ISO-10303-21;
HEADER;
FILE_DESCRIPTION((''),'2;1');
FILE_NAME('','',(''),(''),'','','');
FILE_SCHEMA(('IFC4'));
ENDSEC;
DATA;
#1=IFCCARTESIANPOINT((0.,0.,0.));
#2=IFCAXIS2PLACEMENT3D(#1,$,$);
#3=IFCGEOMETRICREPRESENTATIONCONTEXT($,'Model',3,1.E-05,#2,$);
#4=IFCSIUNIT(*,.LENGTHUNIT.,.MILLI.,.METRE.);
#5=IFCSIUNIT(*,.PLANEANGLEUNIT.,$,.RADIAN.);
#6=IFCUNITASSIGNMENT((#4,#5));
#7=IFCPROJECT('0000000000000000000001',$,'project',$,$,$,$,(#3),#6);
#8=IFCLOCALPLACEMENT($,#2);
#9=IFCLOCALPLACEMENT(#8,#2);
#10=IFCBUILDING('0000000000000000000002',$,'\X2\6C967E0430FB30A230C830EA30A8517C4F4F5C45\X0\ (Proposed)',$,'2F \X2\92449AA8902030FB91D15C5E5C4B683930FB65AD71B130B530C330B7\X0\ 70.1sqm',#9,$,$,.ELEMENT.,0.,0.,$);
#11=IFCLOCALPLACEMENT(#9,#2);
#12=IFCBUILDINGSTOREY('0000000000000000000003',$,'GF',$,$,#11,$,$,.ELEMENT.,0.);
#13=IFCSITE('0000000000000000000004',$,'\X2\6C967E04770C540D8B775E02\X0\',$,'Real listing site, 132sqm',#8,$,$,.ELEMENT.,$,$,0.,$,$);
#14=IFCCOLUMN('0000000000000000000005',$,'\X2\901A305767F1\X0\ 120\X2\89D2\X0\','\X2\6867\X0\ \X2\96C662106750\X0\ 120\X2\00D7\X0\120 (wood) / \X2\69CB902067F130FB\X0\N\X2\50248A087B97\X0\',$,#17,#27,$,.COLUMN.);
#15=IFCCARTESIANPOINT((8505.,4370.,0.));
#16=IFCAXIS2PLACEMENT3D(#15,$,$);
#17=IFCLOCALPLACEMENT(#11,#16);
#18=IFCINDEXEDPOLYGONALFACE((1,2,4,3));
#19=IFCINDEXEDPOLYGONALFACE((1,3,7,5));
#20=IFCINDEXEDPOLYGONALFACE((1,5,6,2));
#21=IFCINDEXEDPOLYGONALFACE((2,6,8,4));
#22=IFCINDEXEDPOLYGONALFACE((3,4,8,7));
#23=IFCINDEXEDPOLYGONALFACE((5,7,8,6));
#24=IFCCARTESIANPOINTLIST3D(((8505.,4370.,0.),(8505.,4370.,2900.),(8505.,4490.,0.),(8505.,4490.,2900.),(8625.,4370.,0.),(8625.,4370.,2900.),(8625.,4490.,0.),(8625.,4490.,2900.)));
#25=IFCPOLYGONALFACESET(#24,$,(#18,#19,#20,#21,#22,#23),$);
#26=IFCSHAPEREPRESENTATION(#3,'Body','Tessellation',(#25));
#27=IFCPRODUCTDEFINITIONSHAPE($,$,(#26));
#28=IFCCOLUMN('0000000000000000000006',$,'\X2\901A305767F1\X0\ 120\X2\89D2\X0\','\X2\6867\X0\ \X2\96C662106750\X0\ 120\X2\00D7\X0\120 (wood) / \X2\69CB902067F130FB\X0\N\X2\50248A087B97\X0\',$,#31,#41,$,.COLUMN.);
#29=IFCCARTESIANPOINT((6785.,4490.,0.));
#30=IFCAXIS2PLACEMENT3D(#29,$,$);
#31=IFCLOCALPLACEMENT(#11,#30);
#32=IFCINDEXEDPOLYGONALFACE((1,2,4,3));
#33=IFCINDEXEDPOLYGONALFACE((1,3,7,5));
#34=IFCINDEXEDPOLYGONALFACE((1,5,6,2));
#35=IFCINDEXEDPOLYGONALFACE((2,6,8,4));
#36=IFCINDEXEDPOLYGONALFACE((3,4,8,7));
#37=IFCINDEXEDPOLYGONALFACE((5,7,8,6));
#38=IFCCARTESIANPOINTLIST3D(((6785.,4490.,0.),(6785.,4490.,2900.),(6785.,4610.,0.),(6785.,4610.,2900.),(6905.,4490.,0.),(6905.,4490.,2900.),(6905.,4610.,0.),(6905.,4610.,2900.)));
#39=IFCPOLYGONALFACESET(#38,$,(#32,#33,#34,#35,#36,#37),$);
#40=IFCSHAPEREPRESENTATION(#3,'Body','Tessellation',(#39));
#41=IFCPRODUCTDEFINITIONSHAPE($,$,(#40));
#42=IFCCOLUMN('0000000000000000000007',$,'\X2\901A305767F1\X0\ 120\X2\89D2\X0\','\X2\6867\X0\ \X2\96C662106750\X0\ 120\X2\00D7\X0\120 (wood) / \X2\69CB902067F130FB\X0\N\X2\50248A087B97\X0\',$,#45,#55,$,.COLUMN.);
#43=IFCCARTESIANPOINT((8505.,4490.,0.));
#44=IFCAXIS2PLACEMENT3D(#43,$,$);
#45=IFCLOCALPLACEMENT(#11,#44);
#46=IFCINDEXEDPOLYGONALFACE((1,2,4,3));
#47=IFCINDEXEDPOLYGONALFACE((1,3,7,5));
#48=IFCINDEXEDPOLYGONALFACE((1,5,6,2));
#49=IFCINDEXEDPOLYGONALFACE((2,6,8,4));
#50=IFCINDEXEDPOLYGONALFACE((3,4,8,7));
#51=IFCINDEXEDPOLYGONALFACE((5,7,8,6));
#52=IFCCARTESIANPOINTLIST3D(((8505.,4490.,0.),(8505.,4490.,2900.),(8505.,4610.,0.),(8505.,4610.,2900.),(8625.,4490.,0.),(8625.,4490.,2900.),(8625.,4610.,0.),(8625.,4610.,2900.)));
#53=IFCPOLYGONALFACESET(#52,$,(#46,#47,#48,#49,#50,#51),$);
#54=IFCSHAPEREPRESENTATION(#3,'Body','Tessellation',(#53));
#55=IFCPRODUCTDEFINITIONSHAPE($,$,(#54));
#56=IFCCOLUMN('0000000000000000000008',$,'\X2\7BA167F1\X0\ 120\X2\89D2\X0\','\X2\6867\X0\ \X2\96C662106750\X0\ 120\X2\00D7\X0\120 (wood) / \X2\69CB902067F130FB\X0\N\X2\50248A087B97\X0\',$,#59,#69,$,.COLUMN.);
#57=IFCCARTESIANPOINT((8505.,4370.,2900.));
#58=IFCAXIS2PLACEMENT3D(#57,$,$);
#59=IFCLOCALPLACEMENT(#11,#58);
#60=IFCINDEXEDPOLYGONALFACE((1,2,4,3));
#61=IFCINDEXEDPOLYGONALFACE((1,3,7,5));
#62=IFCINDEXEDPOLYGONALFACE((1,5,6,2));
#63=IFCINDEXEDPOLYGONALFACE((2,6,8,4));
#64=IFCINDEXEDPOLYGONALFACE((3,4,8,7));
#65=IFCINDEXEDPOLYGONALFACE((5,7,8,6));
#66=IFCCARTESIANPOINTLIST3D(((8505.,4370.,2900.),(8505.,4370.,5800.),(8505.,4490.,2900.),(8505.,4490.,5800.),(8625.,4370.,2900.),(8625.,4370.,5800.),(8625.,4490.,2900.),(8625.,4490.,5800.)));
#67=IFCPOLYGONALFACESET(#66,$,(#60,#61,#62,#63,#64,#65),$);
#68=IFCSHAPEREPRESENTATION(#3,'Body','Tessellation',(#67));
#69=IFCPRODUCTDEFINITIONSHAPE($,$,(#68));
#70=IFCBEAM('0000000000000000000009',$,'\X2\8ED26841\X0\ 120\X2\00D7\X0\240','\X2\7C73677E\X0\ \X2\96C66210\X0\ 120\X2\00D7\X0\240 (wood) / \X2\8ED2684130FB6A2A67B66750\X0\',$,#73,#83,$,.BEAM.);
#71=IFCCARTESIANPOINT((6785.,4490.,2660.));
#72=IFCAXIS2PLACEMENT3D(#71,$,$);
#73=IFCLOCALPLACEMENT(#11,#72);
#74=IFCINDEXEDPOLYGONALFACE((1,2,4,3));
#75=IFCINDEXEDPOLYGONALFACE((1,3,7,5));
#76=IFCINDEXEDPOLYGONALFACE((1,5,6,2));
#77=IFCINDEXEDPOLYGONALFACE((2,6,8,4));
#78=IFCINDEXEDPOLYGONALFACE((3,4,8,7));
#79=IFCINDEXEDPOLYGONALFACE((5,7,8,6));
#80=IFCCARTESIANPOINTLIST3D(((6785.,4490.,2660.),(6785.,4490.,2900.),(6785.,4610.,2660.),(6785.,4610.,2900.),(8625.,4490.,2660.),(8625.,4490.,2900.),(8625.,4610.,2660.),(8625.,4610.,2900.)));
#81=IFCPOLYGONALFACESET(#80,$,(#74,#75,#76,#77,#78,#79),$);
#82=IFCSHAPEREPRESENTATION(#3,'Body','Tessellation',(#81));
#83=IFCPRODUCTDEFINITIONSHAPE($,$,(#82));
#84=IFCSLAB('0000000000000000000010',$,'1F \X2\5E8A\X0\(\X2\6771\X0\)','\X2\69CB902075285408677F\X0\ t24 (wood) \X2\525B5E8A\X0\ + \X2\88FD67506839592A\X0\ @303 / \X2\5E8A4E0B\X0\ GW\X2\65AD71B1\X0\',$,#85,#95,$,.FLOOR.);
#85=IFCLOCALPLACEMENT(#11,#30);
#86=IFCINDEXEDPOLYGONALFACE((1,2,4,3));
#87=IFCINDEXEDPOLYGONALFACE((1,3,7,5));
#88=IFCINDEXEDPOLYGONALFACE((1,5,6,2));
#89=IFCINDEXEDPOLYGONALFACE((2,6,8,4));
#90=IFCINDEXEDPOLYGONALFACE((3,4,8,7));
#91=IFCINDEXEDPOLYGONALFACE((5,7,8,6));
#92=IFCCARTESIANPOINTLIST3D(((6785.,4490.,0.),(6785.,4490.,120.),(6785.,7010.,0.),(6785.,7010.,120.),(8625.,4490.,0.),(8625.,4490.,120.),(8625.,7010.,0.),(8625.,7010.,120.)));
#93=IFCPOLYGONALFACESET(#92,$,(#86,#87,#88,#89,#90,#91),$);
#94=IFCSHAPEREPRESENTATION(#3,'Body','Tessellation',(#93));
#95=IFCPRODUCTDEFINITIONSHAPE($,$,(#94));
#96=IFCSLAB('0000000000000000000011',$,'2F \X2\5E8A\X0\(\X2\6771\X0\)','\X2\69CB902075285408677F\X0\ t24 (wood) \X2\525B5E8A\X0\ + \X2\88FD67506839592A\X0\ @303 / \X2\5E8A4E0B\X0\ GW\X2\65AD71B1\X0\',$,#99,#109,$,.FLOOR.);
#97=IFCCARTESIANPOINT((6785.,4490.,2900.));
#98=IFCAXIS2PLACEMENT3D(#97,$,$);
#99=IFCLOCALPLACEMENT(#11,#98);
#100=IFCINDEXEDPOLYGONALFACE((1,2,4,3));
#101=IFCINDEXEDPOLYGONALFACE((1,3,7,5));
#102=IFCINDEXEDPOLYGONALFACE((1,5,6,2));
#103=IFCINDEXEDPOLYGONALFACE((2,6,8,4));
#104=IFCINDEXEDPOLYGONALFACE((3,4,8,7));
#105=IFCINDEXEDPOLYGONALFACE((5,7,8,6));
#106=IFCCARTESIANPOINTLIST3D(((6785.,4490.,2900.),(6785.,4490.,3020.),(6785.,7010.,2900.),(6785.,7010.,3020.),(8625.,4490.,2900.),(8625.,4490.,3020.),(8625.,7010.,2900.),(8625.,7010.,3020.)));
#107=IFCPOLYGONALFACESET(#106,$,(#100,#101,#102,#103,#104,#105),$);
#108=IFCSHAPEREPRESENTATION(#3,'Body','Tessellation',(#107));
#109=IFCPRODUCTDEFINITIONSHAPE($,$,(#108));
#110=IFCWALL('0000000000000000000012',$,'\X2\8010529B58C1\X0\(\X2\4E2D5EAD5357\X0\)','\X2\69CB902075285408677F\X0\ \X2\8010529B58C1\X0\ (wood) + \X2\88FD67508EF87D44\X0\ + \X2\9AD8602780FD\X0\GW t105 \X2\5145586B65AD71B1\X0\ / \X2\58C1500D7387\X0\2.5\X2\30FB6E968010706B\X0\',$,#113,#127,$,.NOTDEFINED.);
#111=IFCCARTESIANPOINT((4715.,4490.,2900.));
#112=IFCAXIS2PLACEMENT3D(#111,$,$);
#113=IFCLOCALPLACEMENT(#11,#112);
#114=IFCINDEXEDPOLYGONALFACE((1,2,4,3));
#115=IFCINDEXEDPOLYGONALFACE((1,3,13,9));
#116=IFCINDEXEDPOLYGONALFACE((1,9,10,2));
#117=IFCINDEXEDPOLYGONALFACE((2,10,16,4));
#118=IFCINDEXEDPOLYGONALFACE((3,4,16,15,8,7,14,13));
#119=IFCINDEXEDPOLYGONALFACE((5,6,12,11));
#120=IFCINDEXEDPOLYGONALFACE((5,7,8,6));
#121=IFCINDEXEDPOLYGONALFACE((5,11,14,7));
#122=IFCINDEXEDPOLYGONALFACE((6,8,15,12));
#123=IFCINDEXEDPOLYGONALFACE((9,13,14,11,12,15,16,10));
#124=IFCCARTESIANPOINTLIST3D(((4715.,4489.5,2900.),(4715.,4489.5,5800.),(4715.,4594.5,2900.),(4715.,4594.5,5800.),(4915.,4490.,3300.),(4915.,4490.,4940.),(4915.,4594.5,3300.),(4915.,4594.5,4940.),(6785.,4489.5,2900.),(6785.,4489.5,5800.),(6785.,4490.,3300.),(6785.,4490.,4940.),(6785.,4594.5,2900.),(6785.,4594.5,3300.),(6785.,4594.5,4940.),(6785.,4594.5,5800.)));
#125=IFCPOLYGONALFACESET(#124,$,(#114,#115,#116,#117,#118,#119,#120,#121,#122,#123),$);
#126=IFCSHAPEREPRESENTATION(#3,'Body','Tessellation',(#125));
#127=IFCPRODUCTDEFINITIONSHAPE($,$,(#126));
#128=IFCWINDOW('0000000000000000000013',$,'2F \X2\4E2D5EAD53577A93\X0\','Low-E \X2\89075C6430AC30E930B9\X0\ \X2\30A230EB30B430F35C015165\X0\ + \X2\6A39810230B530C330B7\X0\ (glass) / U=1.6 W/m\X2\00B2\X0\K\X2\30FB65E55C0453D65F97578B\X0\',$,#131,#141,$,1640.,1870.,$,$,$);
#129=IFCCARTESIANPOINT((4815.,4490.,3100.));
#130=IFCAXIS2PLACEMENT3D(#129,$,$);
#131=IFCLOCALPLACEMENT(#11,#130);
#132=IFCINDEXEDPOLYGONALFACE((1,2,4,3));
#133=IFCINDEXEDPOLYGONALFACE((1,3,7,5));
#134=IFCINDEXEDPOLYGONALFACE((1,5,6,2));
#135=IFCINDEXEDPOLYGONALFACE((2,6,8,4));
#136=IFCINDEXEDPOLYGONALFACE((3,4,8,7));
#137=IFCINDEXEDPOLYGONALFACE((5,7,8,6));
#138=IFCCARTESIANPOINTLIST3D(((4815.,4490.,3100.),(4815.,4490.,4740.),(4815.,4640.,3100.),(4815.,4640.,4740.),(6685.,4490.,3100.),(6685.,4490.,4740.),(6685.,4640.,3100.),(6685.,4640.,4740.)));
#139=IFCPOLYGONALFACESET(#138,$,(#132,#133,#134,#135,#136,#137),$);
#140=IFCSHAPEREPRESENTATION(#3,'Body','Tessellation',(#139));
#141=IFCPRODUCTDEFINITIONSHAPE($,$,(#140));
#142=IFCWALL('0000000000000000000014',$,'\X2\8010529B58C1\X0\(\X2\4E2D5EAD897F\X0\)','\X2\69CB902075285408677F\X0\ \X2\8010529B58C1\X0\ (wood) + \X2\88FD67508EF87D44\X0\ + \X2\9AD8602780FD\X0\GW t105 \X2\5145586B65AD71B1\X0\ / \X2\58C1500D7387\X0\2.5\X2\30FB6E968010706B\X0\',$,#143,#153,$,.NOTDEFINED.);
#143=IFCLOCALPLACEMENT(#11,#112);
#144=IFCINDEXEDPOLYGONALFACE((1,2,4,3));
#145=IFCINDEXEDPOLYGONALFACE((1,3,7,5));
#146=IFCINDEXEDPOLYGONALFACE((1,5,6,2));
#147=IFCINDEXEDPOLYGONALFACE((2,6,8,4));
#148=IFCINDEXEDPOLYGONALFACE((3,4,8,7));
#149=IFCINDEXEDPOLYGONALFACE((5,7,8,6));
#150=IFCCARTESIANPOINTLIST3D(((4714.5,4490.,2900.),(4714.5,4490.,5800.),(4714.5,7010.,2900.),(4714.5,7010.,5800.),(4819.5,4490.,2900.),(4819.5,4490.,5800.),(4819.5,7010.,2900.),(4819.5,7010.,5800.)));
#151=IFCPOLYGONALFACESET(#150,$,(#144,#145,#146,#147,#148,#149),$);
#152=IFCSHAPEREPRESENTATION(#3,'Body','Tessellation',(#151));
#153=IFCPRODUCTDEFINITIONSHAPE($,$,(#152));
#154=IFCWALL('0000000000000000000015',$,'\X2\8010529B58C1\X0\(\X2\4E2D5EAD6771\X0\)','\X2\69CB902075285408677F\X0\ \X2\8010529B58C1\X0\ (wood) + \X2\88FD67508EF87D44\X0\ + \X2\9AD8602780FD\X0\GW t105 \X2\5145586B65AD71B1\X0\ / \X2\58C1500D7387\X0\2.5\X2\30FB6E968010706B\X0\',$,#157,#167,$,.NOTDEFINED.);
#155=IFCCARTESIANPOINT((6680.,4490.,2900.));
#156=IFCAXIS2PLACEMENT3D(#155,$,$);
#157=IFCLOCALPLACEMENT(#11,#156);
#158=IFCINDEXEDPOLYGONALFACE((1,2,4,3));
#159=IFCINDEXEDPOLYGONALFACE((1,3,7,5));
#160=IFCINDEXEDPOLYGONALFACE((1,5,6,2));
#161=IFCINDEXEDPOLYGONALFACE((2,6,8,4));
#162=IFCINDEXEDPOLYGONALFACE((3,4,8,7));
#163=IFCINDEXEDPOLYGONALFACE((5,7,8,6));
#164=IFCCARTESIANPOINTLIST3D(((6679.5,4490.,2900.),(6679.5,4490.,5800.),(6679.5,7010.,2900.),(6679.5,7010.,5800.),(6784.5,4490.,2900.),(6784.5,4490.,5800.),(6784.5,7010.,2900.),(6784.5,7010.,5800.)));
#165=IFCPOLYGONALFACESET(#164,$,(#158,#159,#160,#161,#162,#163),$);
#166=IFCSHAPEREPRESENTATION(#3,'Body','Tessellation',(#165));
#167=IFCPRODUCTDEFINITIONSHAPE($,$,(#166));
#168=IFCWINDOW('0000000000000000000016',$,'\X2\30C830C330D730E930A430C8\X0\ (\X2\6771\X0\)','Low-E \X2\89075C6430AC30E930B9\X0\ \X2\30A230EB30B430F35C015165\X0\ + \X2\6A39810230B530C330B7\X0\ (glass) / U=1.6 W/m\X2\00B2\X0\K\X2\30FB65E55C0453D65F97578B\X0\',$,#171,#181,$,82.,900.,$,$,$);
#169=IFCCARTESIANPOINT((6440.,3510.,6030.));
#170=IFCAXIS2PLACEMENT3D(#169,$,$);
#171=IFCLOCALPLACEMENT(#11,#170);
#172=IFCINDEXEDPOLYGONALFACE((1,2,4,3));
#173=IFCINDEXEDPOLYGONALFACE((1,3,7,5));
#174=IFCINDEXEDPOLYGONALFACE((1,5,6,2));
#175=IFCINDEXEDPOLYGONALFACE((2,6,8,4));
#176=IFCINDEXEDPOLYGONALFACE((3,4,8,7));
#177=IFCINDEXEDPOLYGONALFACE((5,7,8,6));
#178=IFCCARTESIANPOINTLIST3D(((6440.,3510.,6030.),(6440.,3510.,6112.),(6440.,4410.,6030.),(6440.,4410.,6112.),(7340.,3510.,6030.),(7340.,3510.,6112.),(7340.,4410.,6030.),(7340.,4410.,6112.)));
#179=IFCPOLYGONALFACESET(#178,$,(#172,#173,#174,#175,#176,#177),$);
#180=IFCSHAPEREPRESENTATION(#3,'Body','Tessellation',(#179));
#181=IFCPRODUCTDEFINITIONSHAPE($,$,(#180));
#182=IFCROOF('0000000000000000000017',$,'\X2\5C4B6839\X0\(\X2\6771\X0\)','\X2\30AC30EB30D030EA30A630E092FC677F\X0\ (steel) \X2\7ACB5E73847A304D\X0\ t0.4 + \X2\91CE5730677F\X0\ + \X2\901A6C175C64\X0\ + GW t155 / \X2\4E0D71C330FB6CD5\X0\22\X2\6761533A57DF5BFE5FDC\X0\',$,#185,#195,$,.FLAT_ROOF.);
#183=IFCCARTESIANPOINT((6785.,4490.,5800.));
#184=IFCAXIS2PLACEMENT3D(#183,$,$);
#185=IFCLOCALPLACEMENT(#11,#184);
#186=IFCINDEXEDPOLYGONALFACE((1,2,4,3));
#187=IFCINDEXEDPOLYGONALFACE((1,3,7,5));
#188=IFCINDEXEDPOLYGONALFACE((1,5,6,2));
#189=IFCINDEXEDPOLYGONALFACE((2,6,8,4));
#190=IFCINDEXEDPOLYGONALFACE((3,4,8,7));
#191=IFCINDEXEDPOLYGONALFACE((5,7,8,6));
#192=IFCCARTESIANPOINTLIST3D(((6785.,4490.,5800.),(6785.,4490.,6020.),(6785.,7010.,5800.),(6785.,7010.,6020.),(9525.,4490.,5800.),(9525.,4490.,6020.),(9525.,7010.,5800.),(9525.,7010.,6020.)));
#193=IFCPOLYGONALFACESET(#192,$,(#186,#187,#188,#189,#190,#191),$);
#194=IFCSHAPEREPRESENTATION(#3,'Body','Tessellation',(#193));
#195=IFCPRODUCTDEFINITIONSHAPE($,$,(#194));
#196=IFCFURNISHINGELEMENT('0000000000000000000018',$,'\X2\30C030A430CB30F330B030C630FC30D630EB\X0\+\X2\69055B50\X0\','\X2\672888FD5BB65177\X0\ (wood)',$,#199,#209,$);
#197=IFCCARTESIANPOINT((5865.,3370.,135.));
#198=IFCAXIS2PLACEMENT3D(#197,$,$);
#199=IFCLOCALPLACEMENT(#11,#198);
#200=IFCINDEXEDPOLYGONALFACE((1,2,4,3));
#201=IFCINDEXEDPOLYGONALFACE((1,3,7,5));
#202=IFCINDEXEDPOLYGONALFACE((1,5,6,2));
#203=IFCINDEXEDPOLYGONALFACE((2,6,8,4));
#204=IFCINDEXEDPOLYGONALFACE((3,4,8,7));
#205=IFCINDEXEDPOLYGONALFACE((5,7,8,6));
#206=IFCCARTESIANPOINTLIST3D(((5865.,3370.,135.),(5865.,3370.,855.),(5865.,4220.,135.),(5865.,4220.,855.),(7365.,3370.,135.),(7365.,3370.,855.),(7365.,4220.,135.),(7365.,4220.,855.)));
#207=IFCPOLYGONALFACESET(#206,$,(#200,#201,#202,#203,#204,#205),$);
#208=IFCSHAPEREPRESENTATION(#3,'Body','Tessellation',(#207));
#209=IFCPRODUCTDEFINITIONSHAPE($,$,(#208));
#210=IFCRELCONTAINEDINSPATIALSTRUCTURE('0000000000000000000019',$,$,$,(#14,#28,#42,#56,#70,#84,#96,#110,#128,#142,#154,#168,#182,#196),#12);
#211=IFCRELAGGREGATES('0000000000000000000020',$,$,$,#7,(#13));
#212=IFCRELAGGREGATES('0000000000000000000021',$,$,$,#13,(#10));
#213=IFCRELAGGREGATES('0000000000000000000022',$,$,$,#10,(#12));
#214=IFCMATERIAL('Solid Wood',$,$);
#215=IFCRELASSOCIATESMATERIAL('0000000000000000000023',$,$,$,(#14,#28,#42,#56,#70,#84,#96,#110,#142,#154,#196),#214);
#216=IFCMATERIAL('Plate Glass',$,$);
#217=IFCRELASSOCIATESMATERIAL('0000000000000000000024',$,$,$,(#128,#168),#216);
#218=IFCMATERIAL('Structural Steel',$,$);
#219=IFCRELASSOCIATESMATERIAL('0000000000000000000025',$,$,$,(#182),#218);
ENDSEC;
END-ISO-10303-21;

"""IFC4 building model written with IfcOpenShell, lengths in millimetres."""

from ifc_helpers import new_model, si_unit, frame, frame_2d, origin, place, context, project, spatial, rectangle, extrude, material, element, fill, save


model = new_model("IFC4")

# Units and contexts
model_context = context("Model", 3, precision=1e-05, world=origin())
ifc_project = project(units=[si_unit("LENGTHUNIT", "METRE", prefix="MILLI"), si_unit("PLANEANGLEUNIT", "RADIAN")], contexts=[model_context])

# Site, building, storey
site_placement = place(None, origin())
site = spatial("IfcSite", under=ifc_project, at=site_placement, Name="沖縄県名護市", ObjectType="Real listing site, 132sqm", CompositionType="ELEMENT", RefElevation=0.0)
building_placement = place(site_placement, origin())
building = spatial("IfcBuilding", under=site, at=building_placement, Name="沖縄・アトリエ兼住居 (Proposed)", ObjectType="2F 鉄骨造・金属屋根・断熱サッシ 70.1sqm", CompositionType="ELEMENT", ElevationOfRefHeight=0.0, ElevationOfTerrain=0.0)
storey_placement = place(building_placement, origin())
storey = spatial("IfcBuildingStorey", under=building, at=storey_placement, Name="GF", CompositionType="ELEMENT", Elevation=0.0)

# Columns
ifc_material_1 = material(Name="Solid Wood")
column_1_placement = place(storey_placement, frame((8505.0, 4370.0, 0.0)))
element("IfcColumn", 1, at=column_1_placement, inside=storey, material=ifc_material_1, Name="通し柱 120角", Description="桧 集成材 120×120 (wood) / 構造柱・N値計算", PredefinedType="COLUMN", context=model_context, shape_type="SweptSolid", body=[
    extrude(rectangle(XDim=120.0, YDim=120.0, at=frame_2d((60.0, 60.0))), frame((8505.0, 4370.0, 0.0)), (0.0, 0.0, 1.0), 2900.0),
])
column_2_placement = place(storey_placement, frame((6785.0, 4490.0, 0.0)))
element("IfcColumn", 2, at=column_2_placement, inside=storey, material=ifc_material_1, Name="通し柱 120角", Description="桧 集成材 120×120 (wood) / 構造柱・N値計算", PredefinedType="COLUMN", context=model_context, shape_type="SweptSolid", body=[
    extrude(rectangle(XDim=120.0, YDim=120.0, at=frame_2d((60.0, 60.0))), frame((6785.0, 4490.0, 0.0)), (0.0, 0.0, 1.0), 2900.0),
])
column_3_placement = place(storey_placement, frame((8505.0, 4490.0, 0.0)))
element("IfcColumn", 3, at=column_3_placement, inside=storey, material=ifc_material_1, Name="通し柱 120角", Description="桧 集成材 120×120 (wood) / 構造柱・N値計算", PredefinedType="COLUMN", context=model_context, shape_type="SweptSolid", body=[
    extrude(rectangle(XDim=120.0, YDim=120.0, at=frame_2d((60.0, 60.0))), frame((8505.0, 4490.0, 0.0)), (0.0, 0.0, 1.0), 2900.0),
])
column_4_placement = place(storey_placement, frame((8505.0, 4370.0, 2900.0)))
element("IfcColumn", 4, at=column_4_placement, inside=storey, material=ifc_material_1, Name="管柱 120角", Description="桧 集成材 120×120 (wood) / 構造柱・N値計算", PredefinedType="COLUMN", context=model_context, shape_type="SweptSolid", body=[
    extrude(rectangle(XDim=120.0, YDim=120.0, at=frame_2d((60.0, 60.0))), frame((8505.0, 4370.0, 2900.0)), (0.0, 0.0, 1.0), 2900.0),
])

# Beam
beam_1_placement = place(storey_placement, frame((6785.0, 4490.0, 2660.0)))
element("IfcBeam", 5, at=beam_1_placement, inside=storey, material=ifc_material_1, Name="軒桁 120×240", Description="米松 集成 120×240 (wood) / 軒桁・横架材", PredefinedType="BEAM", context=model_context, shape_type="SweptSolid", body=[
    extrude(rectangle(XDim=1840.0, YDim=120.0, at=frame_2d((920.0, 60.0))), frame((6785.0, 4490.0, 2660.0)), (0.0, 0.0, 1.0), 240.0),
])

# Slabs
slab_1_placement = place(storey_placement, frame((6785.0, 4490.0, 0.0)))
element("IfcSlab", 6, at=slab_1_placement, inside=storey, material=ifc_material_1, Name="1F 床(東)", Description="構造用合板 t24 (wood) 剛床 + 製材根太 @303 / 床下 GW断熱", PredefinedType="FLOOR", context=model_context, shape_type="SweptSolid", body=[
    extrude(rectangle(XDim=1840.0, YDim=2520.0, at=frame_2d((920.0, 1260.0))), frame((6785.0, 4490.0, 0.0)), (0.0, 0.0, 1.0), 120.0),
])
slab_2_placement = place(storey_placement, frame((6785.0, 4490.0, 2900.0)))
element("IfcSlab", 7, at=slab_2_placement, inside=storey, material=ifc_material_1, Name="2F 床(東)", Description="構造用合板 t24 (wood) 剛床 + 製材根太 @303 / 床下 GW断熱", PredefinedType="FLOOR", context=model_context, shape_type="SweptSolid", body=[
    extrude(rectangle(XDim=1840.0, YDim=2520.0, at=frame_2d((920.0, 1260.0))), frame((6785.0, 4490.0, 2900.0)), (0.0, 0.0, 1.0), 120.0),
])

# Wall, opening, window
wall_1_placement = place(storey_placement, frame((4715.0, 4490.0, 2900.0)))
wall_1 = element("IfcWall", 8, at=wall_1_placement, inside=storey, material=ifc_material_1, Name="耐力壁(中庭南)", Description="構造用合板 耐力壁 (wood) + 製材軸組 + 高性能GW t105 充填断熱 / 壁倍率2.5・準耐火", PredefinedType="NOTDEFINED", context=model_context, shape_type="SweptSolid", body=[
    extrude(rectangle(XDim=2070.0, YDim=105.0, at=frame_2d((1035.0, 52.0))), frame((4715.0, 4490.0, 2900.0)), (0.0, 0.0, 1.0), 2900.0),
])
opening_placement = place(storey_placement, frame((4815.0, 4490.0, 3100.0)))
opening = element("IfcOpeningElement", 9, at=opening_placement, cuts=wall_1, PredefinedType="NOTDEFINED", context=model_context, shape_type="SweptSolid", body=[
    extrude(rectangle(XDim=1870.0, YDim=150.0, at=frame_2d((935.0, 75.0))), frame((4815.0, 4490.0, 3100.0)), (0.0, 0.0, 1.0), 1640.0),
])
ifc_material_2 = material(Name="Plate Glass")
window_1_placement = place(storey_placement, frame((4815.0, 4490.0, 3100.0)))
window_1 = element("IfcWindow", 10, at=window_1_placement, inside=storey, material=ifc_material_2, Name="2F 中庭南窓", Description="Low-E 複層ガラス アルゴン封入 + 樹脂サッシ (glass) / U=1.6 W/m²K・日射取得型", OverallHeight=1640.0, OverallWidth=1870.0, context=model_context, shape_type="SweptSolid", body=[
    extrude(rectangle(XDim=1870.0, YDim=150.0, at=frame_2d((935.0, 75.0))), frame((4815.0, 4490.0, 3100.0)), (0.0, 0.0, 1.0), 1640.0),
])
fill(opening, window_1)

# Walls
wall_2_placement = place(storey_placement, frame((4715.0, 4490.0, 2900.0)))
element("IfcWall", 11, at=wall_2_placement, inside=storey, material=ifc_material_1, Name="耐力壁(中庭西)", Description="構造用合板 耐力壁 (wood) + 製材軸組 + 高性能GW t105 充填断熱 / 壁倍率2.5・準耐火", PredefinedType="NOTDEFINED", context=model_context, shape_type="SweptSolid", body=[
    extrude(rectangle(XDim=105.0, YDim=2520.0, at=frame_2d((52.0, 1260.0))), frame((4715.0, 4490.0, 2900.0)), (0.0, 0.0, 1.0), 2900.0),
])
wall_3_placement = place(storey_placement, frame((6680.0, 4490.0, 2900.0)))
element("IfcWall", 12, at=wall_3_placement, inside=storey, material=ifc_material_1, Name="耐力壁(中庭東)", Description="構造用合板 耐力壁 (wood) + 製材軸組 + 高性能GW t105 充填断熱 / 壁倍率2.5・準耐火", PredefinedType="NOTDEFINED", context=model_context, shape_type="SweptSolid", body=[
    extrude(rectangle(XDim=105.0, YDim=2520.0, at=frame_2d((52.0, 1260.0))), frame((6680.0, 4490.0, 2900.0)), (0.0, 0.0, 1.0), 2900.0),
])

# Window
window_2_placement = place(storey_placement, frame((6440.0, 3510.0, 6030.0)))
element("IfcWindow", 13, at=window_2_placement, inside=storey, material=ifc_material_2, Name="トップライト (東)", Description="Low-E 複層ガラス アルゴン封入 + 樹脂サッシ (glass) / U=1.6 W/m²K・日射取得型", OverallHeight=82.0, OverallWidth=900.0, context=model_context, shape_type="SweptSolid", body=[
    extrude(rectangle(XDim=900.0, YDim=900.0, at=frame_2d((450.0, 450.0))), frame((6440.0, 3510.0, 6030.0)), (0.0, 0.0, 1.0), 82.0),
])

# Roof
ifc_material_3 = material(Name="Structural Steel")
for number, where, name in (
    (14, (6785.0, 4490.0, 5800.0), "屋根(東)"),
):
    element("IfcRoof", number, at=place(storey_placement, frame(where)), inside=storey, material=ifc_material_3, Name=name, Description="ガルバリウム鋼板 (steel) 立平葺き t0.4 + 野地板 + 通気層 + GW t155 / 不燃・法22条区域対応", PredefinedType="FLAT_ROOF", context=model_context, shape_type="SweptSolid", body=[
        extrude(rectangle(XDim=2740.0, YDim=2520.0, at=frame_2d((1370.0, 1260.0))), frame((6785.0, 4490.0, 5800.0)), (0.0, 0.0, 1.0), 220.0),
    ])

# Furnishing element
furnishing_1_placement = place(storey_placement, frame((5865.0, 3370.0, 135.0)))
element("IfcFurnishingElement", 15, at=furnishing_1_placement, inside=storey, material=ifc_material_1, Name="ダイニングテーブル+椅子", Description="木製家具 (wood)", context=model_context, shape_type="SweptSolid", body=[
    extrude(rectangle(XDim=1500.0, YDim=850.0, at=frame_2d((750.0, 425.0))), frame((5865.0, 3370.0, 135.0)), (0.0, 0.0, 1.0), 720.0),
])

save(model, "model.ifc")
